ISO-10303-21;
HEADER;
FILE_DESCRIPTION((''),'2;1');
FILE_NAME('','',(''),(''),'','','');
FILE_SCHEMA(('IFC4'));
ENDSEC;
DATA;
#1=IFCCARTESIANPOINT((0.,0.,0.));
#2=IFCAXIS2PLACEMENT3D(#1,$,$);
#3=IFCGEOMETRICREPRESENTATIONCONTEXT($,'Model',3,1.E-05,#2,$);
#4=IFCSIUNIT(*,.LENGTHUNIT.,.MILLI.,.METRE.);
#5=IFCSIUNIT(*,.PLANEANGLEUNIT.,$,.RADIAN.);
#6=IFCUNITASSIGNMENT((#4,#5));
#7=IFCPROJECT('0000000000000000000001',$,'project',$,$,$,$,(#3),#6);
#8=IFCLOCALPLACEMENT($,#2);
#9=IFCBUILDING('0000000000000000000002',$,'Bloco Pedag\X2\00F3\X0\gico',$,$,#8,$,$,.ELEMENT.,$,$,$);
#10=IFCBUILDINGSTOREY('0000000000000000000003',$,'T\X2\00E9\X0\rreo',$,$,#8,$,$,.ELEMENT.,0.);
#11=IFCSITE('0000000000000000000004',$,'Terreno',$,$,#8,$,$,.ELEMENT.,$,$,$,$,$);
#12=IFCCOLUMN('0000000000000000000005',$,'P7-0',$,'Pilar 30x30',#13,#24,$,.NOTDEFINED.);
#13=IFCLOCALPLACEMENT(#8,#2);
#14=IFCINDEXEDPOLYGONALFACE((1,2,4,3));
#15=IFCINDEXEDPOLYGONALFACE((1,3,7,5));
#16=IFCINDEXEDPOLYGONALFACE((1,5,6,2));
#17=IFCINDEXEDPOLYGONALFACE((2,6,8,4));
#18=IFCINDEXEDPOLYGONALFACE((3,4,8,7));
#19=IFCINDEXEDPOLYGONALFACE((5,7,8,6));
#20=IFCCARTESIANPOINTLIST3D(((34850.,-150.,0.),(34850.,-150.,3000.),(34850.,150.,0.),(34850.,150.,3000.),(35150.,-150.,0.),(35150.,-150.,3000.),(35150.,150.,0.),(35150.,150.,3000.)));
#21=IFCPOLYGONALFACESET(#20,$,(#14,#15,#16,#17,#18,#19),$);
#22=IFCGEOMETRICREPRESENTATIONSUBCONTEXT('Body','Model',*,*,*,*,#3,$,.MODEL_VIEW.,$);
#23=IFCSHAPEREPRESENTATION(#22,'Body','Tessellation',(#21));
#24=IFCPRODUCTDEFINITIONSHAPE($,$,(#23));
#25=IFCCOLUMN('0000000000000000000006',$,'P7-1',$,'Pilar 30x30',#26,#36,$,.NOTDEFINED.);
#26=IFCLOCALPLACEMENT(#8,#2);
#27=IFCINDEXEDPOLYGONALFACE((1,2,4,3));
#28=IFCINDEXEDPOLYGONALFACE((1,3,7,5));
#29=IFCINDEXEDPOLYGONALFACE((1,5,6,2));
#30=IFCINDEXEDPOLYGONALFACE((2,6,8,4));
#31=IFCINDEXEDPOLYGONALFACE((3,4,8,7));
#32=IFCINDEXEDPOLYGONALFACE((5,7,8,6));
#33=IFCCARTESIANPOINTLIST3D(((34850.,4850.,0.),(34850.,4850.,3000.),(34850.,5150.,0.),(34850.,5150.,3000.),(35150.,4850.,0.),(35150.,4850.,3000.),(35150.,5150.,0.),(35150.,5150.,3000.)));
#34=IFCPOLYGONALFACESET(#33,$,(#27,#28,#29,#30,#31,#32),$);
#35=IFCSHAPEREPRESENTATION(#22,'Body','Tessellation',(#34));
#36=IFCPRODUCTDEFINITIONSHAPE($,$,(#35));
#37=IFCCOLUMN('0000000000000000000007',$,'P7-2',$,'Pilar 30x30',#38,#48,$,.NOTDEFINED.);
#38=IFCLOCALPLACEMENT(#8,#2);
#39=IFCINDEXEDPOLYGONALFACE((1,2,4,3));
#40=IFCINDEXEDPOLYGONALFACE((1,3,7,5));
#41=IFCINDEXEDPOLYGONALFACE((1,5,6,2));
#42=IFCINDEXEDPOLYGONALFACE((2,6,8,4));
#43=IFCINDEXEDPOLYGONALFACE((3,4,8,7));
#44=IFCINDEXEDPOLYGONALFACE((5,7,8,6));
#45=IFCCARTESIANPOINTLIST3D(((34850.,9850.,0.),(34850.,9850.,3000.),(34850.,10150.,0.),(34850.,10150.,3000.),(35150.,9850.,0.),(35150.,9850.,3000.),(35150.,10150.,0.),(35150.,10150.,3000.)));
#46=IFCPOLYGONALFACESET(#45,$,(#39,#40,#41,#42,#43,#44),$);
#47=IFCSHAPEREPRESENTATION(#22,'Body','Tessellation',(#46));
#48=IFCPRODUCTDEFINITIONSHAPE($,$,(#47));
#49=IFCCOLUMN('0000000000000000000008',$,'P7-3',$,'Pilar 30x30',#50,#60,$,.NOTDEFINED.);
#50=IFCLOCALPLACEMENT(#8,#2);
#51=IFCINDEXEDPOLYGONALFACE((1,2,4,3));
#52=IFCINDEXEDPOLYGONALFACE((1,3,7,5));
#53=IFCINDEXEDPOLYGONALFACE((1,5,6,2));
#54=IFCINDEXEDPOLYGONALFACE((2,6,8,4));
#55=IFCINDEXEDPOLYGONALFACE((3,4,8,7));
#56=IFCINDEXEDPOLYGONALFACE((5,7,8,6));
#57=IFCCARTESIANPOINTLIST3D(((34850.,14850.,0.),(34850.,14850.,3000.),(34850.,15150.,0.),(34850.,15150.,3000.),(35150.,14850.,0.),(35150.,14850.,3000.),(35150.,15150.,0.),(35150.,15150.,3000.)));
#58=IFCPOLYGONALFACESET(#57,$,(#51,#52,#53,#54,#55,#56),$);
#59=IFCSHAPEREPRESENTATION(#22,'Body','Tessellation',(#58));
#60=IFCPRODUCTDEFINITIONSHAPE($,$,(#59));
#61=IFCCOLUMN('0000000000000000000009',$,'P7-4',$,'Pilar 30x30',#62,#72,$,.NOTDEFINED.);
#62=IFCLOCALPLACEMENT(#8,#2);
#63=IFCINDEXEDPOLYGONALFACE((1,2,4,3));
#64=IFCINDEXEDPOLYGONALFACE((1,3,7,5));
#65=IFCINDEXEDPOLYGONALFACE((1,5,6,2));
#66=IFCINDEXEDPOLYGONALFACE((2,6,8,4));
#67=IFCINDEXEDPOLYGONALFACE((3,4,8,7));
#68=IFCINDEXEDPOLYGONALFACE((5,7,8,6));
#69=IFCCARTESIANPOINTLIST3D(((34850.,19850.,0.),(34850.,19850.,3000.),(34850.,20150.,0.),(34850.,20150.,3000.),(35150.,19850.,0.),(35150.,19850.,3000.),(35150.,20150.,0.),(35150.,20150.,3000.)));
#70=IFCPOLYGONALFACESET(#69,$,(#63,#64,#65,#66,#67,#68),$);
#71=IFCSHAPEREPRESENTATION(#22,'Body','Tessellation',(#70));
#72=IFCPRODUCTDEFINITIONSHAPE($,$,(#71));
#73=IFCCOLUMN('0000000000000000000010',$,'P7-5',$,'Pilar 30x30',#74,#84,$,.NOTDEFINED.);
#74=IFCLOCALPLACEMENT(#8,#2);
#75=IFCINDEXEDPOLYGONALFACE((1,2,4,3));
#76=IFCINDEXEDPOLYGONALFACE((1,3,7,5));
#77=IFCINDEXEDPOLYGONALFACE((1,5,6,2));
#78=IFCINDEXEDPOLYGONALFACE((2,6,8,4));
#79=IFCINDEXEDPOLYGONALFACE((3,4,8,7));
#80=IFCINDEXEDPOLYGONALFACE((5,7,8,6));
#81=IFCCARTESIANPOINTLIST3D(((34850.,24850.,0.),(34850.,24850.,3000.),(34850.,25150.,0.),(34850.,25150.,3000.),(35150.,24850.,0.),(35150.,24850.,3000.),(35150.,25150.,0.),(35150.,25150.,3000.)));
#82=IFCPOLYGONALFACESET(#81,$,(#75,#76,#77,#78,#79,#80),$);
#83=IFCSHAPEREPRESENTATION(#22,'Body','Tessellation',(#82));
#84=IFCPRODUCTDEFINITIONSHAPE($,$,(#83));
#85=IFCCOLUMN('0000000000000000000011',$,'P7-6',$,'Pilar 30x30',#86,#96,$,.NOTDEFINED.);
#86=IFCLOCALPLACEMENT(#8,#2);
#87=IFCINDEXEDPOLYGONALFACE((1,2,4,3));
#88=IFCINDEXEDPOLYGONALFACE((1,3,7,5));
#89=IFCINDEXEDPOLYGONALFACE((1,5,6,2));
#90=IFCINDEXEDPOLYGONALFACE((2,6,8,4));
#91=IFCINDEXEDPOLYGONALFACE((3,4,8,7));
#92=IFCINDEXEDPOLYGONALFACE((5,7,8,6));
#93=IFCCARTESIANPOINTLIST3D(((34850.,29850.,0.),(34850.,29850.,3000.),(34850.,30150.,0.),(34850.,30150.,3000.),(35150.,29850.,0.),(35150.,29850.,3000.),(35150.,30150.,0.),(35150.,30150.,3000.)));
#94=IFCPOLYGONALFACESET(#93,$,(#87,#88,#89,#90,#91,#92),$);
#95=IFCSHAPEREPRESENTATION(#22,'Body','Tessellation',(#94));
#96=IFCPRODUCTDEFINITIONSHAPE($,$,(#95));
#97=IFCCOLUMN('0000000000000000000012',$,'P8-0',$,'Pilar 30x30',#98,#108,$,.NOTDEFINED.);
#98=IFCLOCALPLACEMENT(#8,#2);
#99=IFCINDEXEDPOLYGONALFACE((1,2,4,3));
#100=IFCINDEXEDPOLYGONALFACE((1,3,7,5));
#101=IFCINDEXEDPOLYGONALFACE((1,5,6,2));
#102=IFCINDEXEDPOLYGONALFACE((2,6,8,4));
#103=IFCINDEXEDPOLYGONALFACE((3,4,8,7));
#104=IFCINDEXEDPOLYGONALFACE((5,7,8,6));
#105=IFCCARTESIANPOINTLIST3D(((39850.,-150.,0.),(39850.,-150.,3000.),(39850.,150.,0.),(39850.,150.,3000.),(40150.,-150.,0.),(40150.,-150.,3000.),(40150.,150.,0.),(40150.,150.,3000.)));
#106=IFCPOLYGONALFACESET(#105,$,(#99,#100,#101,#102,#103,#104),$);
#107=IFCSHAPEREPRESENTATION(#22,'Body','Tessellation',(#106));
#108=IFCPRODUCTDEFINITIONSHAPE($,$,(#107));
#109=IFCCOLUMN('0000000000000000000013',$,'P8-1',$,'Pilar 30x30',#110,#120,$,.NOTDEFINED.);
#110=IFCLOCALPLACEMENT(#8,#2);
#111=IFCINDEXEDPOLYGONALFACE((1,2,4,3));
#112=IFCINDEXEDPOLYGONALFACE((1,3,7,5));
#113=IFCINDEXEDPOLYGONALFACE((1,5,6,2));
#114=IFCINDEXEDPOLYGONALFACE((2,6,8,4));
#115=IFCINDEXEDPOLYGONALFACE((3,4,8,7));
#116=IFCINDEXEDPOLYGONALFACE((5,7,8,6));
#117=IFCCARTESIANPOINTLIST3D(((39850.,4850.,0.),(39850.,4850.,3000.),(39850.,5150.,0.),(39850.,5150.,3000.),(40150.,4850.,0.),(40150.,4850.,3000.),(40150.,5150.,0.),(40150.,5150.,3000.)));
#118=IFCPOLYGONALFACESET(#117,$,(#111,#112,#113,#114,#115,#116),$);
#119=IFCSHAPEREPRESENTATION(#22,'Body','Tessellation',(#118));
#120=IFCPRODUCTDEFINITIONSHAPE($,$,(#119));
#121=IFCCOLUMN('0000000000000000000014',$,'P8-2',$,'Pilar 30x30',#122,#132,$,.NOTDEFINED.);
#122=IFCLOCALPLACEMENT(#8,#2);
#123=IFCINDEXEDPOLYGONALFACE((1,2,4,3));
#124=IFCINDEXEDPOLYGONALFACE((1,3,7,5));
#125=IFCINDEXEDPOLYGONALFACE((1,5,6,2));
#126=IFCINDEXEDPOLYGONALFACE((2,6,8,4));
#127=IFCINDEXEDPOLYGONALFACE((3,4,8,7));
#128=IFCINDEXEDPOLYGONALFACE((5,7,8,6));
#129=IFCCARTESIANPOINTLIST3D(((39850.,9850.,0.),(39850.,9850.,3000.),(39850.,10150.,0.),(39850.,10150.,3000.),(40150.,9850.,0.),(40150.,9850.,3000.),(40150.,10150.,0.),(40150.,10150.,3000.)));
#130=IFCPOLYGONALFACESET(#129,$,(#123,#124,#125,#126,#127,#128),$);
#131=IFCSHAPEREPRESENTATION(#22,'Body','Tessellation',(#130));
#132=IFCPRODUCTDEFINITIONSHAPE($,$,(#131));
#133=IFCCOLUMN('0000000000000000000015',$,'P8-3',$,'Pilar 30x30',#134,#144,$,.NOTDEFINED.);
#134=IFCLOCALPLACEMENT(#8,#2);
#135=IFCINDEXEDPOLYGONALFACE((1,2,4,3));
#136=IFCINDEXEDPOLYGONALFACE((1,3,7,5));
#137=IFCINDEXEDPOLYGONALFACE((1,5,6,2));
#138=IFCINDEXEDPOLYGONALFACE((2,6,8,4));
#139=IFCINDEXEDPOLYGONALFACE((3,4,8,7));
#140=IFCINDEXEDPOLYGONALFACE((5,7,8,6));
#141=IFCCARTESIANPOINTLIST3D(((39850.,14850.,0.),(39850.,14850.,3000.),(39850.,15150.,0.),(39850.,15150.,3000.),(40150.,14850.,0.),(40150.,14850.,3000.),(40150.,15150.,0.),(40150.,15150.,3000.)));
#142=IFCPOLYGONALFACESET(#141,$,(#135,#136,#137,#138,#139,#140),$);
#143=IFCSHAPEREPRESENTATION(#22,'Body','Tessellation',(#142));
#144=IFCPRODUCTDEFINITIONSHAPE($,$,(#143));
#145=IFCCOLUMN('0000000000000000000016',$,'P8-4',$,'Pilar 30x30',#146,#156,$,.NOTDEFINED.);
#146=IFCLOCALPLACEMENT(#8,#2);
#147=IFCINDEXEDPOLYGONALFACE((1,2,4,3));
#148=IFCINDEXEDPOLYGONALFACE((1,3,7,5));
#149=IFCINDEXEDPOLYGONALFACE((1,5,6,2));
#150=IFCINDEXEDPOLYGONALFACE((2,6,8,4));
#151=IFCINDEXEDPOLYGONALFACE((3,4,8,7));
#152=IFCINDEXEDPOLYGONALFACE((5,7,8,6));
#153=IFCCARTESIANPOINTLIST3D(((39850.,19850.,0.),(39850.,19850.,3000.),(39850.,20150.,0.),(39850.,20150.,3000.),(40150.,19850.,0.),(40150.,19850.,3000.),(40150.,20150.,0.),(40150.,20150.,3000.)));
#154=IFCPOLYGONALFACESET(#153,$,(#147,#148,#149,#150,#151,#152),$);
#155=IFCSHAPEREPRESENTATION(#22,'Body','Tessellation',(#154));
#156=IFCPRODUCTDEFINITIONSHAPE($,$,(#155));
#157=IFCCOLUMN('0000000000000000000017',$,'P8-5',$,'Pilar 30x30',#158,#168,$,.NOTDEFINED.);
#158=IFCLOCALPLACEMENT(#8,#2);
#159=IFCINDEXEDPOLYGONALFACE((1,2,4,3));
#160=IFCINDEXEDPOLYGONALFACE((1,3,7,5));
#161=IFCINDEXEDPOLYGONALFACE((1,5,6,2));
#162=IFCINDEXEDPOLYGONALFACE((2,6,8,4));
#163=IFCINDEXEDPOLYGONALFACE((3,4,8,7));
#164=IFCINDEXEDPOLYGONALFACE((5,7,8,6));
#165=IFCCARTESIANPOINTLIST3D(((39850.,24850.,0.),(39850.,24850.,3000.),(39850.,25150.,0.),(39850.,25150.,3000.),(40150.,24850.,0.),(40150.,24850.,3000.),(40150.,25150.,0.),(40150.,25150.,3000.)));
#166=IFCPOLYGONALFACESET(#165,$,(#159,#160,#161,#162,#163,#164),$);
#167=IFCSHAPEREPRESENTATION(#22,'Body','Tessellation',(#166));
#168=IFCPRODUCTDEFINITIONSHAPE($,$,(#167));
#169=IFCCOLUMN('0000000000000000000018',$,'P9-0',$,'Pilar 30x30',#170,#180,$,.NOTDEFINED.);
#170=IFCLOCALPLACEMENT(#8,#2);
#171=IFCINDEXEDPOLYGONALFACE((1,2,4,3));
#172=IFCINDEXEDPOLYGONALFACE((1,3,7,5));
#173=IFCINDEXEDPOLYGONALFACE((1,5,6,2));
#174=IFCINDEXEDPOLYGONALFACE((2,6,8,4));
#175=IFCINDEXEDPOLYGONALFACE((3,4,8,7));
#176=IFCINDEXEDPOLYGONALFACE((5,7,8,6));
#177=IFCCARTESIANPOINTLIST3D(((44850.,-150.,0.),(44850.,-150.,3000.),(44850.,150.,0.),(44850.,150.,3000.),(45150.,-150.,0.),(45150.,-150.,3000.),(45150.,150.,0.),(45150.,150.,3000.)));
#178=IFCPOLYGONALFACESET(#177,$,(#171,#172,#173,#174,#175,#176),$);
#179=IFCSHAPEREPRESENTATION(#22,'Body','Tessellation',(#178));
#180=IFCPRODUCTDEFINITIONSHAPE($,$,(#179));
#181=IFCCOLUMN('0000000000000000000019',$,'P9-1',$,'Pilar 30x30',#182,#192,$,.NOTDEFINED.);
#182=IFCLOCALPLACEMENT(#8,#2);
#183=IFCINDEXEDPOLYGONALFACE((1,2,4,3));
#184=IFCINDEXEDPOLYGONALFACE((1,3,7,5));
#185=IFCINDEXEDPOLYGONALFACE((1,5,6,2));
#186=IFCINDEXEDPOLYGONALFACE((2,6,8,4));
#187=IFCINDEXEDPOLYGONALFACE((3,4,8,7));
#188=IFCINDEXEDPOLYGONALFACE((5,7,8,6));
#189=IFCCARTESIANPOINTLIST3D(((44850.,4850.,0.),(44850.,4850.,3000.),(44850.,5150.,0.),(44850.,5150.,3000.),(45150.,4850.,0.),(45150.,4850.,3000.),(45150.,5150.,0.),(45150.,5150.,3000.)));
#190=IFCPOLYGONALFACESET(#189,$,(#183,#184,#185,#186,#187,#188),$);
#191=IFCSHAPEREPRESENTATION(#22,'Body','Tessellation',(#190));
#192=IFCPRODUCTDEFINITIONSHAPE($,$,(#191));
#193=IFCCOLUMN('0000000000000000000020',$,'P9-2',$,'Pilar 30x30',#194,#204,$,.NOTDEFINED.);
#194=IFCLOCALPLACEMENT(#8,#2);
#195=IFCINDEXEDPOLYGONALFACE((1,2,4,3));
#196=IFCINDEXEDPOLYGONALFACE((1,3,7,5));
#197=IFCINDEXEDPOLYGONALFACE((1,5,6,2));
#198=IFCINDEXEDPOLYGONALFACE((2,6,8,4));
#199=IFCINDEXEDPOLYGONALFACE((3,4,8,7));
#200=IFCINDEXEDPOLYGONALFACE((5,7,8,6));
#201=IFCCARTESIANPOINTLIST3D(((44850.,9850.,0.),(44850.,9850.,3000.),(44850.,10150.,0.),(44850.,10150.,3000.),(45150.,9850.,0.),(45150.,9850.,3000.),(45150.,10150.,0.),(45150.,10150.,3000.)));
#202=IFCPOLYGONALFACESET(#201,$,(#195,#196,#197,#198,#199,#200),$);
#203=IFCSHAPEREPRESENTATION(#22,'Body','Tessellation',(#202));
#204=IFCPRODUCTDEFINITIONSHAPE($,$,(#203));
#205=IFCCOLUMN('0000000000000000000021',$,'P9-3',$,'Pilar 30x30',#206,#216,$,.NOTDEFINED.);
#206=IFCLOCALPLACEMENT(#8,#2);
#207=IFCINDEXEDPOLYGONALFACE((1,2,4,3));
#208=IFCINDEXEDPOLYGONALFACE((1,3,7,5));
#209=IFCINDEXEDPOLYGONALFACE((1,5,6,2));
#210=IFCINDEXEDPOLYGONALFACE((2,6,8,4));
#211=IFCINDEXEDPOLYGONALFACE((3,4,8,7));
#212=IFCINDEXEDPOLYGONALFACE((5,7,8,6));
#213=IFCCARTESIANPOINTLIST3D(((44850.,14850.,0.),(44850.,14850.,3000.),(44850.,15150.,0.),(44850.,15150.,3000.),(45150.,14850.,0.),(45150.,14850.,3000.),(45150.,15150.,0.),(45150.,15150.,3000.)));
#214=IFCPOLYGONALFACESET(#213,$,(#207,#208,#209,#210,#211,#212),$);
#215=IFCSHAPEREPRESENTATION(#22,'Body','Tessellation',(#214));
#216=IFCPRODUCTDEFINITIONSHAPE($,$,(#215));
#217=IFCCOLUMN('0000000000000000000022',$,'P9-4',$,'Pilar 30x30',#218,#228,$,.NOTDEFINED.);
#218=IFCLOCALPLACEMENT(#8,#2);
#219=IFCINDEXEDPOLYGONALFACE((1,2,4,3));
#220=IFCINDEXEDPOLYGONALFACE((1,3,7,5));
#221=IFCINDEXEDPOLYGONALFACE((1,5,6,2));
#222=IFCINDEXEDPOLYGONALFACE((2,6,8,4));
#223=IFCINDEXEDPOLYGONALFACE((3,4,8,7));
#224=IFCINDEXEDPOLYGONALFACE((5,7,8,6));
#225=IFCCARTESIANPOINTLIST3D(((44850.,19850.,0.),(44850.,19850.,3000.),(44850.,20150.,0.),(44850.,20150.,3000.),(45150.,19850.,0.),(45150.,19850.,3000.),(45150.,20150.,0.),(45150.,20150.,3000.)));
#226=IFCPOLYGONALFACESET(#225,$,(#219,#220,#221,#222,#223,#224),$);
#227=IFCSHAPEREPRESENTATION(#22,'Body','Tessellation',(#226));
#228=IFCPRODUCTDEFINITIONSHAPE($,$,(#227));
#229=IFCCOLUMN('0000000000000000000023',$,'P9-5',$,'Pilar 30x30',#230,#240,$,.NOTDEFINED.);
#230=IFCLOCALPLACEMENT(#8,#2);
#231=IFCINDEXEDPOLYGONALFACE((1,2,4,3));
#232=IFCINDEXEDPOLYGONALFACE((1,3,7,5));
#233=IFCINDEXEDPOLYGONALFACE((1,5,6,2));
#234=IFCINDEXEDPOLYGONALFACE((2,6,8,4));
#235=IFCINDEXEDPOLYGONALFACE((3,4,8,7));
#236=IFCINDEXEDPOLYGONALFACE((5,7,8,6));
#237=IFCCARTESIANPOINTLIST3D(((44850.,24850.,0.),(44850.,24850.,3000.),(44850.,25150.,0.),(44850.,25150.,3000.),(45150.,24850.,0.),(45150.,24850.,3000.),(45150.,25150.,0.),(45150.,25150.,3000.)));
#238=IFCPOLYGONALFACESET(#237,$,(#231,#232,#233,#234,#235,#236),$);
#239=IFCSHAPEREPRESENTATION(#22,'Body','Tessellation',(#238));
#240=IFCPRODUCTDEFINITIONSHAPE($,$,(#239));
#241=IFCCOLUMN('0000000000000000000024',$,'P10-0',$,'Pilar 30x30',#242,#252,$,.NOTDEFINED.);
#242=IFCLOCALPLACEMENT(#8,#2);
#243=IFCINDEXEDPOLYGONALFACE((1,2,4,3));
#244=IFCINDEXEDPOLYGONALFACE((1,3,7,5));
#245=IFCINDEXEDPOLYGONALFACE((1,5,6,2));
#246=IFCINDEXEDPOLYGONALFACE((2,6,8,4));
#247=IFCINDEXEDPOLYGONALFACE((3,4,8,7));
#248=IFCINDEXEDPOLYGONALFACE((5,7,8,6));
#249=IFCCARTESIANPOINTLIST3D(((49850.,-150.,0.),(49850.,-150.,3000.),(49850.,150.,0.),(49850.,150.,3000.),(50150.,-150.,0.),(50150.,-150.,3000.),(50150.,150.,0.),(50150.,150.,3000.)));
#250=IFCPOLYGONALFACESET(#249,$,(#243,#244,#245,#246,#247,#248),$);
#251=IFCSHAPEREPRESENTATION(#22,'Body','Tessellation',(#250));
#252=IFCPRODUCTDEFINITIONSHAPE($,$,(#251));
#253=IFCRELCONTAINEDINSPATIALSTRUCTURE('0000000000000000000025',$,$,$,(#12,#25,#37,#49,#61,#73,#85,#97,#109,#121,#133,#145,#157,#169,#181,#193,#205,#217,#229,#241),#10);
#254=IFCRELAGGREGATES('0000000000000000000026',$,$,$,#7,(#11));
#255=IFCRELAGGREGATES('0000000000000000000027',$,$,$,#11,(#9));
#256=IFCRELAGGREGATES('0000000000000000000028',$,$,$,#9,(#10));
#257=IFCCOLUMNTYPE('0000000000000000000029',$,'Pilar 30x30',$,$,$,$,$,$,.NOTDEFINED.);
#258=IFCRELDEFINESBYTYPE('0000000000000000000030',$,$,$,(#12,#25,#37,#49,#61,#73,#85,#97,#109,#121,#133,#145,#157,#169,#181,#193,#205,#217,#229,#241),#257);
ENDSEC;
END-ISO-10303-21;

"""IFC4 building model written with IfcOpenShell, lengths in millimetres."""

from ifc_helpers import new_model, si_unit, frame, origin, origin_2d, place, context, subcontext, project, spatial, rectangle, extrude, type_object, element, save


model = new_model("IFC4")

# Units and contexts
model_context = context("Model", 3, precision=1e-05, world=origin())
body_context = subcontext(model_context, "Body", "Model", "MODEL_VIEW")
ifc_project = project(units=[si_unit("LENGTHUNIT", "METRE", prefix="MILLI"), si_unit("PLANEANGLEUNIT", "RADIAN")], contexts=[model_context])

# Site, building, storey
placement = place(None, origin())
site = spatial("IfcSite", under=ifc_project, at=placement, Name="Terreno", CompositionType="ELEMENT")
building = spatial("IfcBuilding", under=site, at=placement, Name="Bloco Pedagógico", CompositionType="ELEMENT")
storey = spatial("IfcBuildingStorey", under=building, at=placement, Name="Térreo", CompositionType="ELEMENT", Elevation=0.0)

# Columns
column_type = type_object("IfcColumnType", Name="Pilar 30x30", PredefinedType="NOTDEFINED")
for number, where, z_axis, x_axis, name in (
    (1, (35000.0, 0.0, 0.0), (0.0, 0.0, 1.0), (1.0, 0.0, 0.0), "P7-0"),
    (2, (35000.0, 5000.0, 0.0), (0.0, 0.0, 1.0), (1.0, 0.0, 0.0), "P7-1"),
    (3, (35000.0, 10000.0, 0.0), (0.0, 0.0, 1.0), (1.0, 0.0, 0.0), "P7-2"),
    (4, (35000.0, 15000.0, 0.0), (0.0, 0.0, 1.0), (1.0, 0.0, 0.0), "P7-3"),
    (5, (35000.0, 20000.0, 0.0), (0.0, 0.0, 1.0), (1.0, 0.0, 0.0), "P7-4"),
    (6, (35000.0, 25000.0, 0.0), (0.0, 0.0, 1.0), (1.0, 0.0, 0.0), "P7-5"),
    (7, (35000.0, 30000.0, 0.0), (0.0, 0.0, 1.0), (1.0, 0.0, 0.0), "P7-6"),
    (8, (40000.0, 0.0, 0.0), (0.0, 0.0, 1.0), (1.0, 0.0, 0.0), "P8-0"),
    (9, (40000.0, 5000.0, 0.0), (0.0, 0.0, 1.0), (1.0, 0.0, 0.0), "P8-1"),
    (10, (40000.0, 10000.0, 0.0), (0.0, 0.0, 1.0), (1.0, 0.0, 0.0), "P8-2"),
    (11, (40000.0, 15000.0, 0.0), (0.0, 0.0, 1.0), (1.0, 0.0, 0.0), "P8-3"),
    (12, (40000.0, 20000.0, 0.0), (0.0, 0.0, 1.0), (1.0, 0.0, 0.0), "P8-4"),
    (13, (40000.0, 25000.0, 0.0), (0.0, 0.0, 1.0), (1.0, 0.0, 0.0), "P8-5"),
    (14, (45000.0, 0.0, 0.0), (0.0, 0.0, 1.0), (1.0, 0.0, 0.0), "P9-0"),
    (15, (45000.0, 5000.0, 0.0), (0.0, 0.0, 1.0), (1.0, 0.0, 0.0), "P9-1"),
    (16, (45000.0, 10000.0, 0.0), (0.0, 0.0, 1.0), (1.0, 0.0, 0.0), "P9-2"),
    (17, (45000.0, 15000.0, 0.0), (0.0, 0.0, 1.0), (1.0, 0.0, 0.0), "P9-3"),
    (18, (45000.0, 20000.0, 0.0), (0.0, 0.0, 1.0), (1.0, 0.0, 0.0), "P9-4"),
    (19, (45000.0, 25000.0, 0.0), (0.0, 0.0, 1.0), (1.0, 0.0, 0.0), "P9-5"),
    (20, (50000.0, 0.0, 0.0), (0.0, 0.0, 1.0), (1.0, 0.0, 0.0), "P10-0"),
):
    element("IfcColumn", number, at=place(None, frame(where, z_axis=z_axis, x_axis=x_axis)), inside=storey, type_object=column_type, Name=name, ObjectType="Pilar 30x30", PredefinedType="NOTDEFINED", context=body_context, shape_type="SweptSolid", body=[
        extrude(rectangle(XDim=300.0, YDim=300.0, at=origin_2d()), None, (0.0, 0.0, 1.0), 3000.0),
    ])

save(model, "model.ifc")
